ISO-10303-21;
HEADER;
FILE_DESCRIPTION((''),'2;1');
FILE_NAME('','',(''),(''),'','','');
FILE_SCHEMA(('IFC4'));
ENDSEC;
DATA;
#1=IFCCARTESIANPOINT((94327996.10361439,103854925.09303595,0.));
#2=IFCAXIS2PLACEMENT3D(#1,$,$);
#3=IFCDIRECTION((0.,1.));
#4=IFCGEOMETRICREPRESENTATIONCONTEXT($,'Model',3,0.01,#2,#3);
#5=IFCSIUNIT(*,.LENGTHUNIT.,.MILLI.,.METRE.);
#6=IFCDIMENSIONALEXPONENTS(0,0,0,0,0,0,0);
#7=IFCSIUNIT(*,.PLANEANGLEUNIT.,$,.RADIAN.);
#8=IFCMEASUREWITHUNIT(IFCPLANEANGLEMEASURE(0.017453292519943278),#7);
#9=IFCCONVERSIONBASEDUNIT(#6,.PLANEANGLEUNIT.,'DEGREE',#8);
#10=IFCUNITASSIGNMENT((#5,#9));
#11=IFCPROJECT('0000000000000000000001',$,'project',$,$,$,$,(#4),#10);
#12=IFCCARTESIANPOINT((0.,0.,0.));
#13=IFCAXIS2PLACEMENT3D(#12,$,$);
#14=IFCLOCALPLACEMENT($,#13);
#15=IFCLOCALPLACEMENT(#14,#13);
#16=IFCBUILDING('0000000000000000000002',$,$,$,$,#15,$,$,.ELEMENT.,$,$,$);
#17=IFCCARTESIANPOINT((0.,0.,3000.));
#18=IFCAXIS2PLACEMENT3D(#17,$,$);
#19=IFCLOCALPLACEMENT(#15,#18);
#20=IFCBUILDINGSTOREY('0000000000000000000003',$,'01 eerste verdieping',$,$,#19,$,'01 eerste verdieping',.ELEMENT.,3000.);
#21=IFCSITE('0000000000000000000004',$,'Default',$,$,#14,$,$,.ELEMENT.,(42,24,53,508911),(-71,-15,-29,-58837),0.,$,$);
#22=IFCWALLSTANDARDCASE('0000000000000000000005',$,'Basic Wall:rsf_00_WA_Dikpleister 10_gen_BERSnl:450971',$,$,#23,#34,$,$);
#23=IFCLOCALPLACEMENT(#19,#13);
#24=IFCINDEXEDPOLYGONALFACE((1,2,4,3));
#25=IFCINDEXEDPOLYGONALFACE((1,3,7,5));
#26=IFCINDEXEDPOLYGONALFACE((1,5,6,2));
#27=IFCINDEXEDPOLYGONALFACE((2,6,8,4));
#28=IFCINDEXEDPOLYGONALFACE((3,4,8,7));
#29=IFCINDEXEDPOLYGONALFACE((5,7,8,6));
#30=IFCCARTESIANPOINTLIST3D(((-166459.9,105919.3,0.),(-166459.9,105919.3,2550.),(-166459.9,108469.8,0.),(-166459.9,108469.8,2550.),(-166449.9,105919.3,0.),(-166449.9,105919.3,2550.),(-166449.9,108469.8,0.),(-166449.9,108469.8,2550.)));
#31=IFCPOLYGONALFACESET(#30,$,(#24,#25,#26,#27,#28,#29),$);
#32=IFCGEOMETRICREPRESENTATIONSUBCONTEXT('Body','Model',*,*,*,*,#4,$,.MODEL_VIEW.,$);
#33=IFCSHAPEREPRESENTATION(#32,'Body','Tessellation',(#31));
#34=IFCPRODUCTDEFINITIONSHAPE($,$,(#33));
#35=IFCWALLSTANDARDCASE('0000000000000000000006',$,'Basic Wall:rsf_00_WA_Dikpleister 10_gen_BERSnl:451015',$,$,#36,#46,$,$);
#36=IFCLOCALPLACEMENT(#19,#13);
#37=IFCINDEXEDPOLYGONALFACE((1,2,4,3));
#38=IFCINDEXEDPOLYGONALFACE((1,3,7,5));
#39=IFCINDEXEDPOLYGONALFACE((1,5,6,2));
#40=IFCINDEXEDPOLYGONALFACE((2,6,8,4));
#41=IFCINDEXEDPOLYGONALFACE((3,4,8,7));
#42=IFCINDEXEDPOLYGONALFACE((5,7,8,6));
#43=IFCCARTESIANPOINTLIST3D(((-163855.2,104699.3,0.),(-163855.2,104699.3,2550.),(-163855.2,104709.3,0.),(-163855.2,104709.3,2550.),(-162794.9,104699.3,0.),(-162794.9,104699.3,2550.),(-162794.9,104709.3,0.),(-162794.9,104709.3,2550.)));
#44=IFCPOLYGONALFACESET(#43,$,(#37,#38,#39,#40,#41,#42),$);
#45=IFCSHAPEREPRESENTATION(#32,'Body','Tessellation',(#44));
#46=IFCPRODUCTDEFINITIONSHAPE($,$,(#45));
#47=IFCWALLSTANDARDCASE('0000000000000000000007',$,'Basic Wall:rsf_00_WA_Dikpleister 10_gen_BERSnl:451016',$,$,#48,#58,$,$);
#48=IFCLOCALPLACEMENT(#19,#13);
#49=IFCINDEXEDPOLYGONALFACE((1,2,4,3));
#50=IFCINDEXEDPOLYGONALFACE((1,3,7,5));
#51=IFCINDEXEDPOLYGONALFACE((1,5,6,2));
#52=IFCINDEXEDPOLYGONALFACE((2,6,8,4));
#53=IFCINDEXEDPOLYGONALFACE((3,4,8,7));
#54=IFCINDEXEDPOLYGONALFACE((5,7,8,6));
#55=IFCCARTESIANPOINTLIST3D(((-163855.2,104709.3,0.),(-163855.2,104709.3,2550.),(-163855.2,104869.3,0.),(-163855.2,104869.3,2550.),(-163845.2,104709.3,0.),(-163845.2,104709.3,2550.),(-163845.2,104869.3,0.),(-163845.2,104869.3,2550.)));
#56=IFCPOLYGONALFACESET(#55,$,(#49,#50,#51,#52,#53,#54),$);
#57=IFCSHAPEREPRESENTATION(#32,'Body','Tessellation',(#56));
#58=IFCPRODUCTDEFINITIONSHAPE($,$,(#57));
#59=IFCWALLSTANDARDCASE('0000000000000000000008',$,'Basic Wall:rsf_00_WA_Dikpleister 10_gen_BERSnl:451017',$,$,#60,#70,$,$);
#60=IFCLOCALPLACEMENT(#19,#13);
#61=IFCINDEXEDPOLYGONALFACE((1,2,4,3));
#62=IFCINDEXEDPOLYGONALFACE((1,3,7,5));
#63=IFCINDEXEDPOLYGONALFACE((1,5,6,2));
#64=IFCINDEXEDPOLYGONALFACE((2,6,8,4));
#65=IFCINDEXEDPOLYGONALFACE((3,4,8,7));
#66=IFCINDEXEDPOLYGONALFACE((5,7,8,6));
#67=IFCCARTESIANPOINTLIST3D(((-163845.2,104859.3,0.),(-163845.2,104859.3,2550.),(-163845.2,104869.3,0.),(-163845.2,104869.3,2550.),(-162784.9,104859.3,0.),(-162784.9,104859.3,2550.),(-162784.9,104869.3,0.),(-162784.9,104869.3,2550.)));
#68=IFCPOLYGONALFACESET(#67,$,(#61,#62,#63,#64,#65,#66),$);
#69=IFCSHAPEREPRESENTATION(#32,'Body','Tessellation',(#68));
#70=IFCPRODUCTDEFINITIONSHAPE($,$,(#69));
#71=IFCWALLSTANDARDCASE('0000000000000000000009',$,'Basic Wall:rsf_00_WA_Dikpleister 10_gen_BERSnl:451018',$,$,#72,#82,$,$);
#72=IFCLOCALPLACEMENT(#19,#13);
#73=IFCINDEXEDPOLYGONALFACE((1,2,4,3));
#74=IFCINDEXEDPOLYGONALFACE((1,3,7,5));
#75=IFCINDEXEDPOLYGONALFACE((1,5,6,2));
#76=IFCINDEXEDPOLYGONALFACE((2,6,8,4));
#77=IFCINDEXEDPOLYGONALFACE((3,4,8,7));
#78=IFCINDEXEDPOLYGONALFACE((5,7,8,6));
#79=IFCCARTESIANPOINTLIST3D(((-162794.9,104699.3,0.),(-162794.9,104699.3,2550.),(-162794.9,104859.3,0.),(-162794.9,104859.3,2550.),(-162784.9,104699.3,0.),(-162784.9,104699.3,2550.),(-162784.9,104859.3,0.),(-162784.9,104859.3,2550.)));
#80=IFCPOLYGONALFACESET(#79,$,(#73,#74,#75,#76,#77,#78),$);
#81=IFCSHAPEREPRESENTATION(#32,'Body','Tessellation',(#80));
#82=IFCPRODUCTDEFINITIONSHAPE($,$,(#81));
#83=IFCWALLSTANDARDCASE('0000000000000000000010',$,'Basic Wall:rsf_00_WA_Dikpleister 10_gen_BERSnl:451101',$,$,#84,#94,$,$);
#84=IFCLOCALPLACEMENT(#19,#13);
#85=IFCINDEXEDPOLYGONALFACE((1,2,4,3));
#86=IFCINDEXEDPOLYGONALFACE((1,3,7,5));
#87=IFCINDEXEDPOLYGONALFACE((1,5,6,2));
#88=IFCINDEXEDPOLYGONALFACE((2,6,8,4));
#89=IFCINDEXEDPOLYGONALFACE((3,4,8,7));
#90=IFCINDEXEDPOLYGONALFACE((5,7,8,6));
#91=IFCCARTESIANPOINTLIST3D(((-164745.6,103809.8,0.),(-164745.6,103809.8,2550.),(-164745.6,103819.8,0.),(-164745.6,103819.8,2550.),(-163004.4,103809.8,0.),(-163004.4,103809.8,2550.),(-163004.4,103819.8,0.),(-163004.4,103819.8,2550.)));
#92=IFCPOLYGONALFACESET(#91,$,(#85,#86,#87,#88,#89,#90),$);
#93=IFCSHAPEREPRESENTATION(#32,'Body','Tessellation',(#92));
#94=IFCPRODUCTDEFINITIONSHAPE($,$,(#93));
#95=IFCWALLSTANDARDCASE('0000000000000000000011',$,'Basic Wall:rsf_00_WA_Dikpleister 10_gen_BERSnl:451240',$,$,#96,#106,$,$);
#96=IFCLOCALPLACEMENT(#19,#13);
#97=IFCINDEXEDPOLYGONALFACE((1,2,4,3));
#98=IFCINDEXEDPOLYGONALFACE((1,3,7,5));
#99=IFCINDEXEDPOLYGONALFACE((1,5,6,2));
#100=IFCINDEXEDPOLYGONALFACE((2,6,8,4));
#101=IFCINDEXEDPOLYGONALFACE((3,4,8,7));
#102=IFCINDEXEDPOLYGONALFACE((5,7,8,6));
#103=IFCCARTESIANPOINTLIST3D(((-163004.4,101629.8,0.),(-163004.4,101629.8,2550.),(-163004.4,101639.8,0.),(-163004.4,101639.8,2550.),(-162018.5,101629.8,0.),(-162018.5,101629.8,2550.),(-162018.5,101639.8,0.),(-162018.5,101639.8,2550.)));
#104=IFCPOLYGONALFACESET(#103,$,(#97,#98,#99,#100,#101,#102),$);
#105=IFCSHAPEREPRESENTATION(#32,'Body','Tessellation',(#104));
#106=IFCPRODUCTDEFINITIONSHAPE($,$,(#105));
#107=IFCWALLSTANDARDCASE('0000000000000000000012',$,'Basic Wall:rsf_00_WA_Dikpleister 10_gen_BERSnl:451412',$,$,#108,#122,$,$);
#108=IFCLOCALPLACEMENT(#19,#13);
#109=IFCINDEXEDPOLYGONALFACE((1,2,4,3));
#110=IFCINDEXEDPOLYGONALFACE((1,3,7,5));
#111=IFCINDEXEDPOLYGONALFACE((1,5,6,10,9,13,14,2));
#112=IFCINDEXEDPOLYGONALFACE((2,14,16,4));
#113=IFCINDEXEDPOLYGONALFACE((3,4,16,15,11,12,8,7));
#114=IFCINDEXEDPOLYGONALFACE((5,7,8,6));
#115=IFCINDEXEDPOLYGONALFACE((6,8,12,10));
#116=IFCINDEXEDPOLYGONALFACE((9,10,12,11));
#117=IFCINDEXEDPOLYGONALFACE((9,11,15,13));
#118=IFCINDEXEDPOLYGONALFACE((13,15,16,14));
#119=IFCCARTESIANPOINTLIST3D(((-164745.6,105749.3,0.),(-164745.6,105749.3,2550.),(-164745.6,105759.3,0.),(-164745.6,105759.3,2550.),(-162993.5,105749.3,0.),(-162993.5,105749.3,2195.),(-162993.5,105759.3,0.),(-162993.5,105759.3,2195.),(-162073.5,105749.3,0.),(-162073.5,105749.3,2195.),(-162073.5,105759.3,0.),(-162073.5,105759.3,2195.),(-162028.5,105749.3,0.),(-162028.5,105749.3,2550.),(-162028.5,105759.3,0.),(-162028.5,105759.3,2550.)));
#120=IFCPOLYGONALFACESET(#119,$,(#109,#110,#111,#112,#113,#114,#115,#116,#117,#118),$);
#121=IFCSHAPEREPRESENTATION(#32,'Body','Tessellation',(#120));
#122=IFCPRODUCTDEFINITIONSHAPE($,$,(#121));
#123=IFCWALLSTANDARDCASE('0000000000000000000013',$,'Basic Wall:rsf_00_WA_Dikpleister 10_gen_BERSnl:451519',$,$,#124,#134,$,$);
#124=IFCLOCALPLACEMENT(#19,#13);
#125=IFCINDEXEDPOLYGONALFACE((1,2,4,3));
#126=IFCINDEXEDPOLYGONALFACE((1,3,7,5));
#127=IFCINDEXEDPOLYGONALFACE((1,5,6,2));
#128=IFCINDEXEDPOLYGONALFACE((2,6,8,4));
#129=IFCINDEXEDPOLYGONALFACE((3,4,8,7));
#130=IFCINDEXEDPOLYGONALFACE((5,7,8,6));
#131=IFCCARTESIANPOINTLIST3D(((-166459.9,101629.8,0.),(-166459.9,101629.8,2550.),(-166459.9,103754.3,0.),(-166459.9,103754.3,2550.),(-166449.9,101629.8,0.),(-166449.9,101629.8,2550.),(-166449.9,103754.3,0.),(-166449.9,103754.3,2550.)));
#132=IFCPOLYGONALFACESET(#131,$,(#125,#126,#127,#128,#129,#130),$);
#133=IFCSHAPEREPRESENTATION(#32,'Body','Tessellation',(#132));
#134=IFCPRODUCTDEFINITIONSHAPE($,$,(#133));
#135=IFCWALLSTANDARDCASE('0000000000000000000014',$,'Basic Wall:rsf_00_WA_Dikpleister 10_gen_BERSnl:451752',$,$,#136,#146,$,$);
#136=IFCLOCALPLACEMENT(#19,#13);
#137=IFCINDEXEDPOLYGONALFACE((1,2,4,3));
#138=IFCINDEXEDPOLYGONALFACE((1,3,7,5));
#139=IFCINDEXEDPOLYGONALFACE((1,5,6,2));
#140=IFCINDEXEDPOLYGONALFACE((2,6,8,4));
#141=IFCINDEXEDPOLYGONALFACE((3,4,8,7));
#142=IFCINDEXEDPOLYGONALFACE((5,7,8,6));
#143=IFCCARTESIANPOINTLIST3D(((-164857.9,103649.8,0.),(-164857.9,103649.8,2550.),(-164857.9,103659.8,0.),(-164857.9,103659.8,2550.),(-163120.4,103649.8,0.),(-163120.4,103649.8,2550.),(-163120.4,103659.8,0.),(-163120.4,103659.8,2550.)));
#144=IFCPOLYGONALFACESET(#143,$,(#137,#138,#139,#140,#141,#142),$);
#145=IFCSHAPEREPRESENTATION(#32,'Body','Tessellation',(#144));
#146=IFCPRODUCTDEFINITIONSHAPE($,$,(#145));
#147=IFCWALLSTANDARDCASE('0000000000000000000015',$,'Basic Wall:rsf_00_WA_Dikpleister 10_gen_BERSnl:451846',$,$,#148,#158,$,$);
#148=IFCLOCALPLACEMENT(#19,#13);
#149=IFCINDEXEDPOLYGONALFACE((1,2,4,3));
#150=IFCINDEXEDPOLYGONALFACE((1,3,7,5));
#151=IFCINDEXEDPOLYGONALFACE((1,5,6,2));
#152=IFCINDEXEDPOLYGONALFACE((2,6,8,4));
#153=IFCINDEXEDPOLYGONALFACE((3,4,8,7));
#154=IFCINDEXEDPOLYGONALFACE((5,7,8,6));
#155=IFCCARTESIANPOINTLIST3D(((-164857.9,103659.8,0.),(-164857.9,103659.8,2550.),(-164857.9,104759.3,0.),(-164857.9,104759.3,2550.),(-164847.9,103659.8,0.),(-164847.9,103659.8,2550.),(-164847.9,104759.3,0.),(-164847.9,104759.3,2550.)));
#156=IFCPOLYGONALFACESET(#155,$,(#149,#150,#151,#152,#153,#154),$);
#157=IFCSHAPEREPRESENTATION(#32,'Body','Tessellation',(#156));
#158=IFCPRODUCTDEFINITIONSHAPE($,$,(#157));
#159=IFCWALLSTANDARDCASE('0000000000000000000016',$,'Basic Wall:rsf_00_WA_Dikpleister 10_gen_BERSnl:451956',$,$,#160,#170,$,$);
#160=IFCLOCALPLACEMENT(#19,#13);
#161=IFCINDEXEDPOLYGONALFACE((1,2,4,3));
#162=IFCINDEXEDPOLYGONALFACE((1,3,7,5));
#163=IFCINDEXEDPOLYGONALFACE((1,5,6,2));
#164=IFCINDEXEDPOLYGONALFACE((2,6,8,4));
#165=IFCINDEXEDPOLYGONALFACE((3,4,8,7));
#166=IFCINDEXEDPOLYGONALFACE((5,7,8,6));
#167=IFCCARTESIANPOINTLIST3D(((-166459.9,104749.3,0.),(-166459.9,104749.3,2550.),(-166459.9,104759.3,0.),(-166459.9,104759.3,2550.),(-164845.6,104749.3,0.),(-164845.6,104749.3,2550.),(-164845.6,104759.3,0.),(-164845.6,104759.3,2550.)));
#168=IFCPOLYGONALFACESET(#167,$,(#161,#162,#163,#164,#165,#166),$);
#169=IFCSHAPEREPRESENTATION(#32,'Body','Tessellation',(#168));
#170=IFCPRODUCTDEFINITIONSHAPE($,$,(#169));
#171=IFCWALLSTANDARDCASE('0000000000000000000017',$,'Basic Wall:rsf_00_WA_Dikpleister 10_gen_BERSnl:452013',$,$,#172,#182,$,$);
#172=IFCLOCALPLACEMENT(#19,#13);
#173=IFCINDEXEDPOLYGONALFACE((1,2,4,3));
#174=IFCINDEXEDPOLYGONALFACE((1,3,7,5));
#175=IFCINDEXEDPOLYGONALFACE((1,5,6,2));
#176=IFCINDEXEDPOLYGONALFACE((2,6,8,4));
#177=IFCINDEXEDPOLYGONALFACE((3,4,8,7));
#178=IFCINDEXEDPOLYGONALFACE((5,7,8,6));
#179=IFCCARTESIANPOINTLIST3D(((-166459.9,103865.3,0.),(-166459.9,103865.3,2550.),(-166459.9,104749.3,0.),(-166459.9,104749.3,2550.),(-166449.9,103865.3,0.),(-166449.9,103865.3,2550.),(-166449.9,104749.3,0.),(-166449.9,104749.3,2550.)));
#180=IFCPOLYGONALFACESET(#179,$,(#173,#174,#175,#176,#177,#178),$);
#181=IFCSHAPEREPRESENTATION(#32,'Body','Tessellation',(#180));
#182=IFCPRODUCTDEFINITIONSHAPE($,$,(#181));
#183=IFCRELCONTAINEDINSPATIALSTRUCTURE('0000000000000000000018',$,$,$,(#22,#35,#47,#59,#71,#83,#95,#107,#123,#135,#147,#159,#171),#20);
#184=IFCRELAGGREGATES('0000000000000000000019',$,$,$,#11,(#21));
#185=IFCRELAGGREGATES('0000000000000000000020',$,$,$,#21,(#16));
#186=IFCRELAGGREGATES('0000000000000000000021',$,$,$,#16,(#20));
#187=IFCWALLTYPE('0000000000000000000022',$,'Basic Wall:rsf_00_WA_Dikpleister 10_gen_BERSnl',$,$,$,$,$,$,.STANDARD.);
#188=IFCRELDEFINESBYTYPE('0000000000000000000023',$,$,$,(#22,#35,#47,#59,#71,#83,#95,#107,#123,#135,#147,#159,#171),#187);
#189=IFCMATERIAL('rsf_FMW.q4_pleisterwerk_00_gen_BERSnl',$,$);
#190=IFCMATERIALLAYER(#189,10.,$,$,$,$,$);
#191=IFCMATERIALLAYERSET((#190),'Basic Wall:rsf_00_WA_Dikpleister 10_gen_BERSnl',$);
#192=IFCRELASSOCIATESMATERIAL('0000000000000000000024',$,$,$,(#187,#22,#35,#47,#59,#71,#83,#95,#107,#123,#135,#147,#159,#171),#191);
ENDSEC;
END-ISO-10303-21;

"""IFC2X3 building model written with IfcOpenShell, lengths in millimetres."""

from ifc_helpers import new_model, entity, si_unit, converted_unit, direction, frame, frame_2d, origin, place, context, subcontext, project, spatial, rectangle, extrude, material, layer, layer_set, layer_usage, type_object, element, save


model = new_model("IFC2X3")

# Units and contexts
model_context = context("Model", 3, precision=0.01, world=frame((94327996.10361439, 103854925.09303595, 0.0)), true_north=direction((0.0, 1.0)))
body_context = subcontext(model_context, "Body", "Model", "MODEL_VIEW")
ifc_project = project(units=[si_unit("LENGTHUNIT", "METRE", prefix="MILLI"), converted_unit("PLANEANGLEUNIT", "DEGREE", entity("IfcPlaneAngleMeasure", 0.017453292519943278), si_unit("PLANEANGLEUNIT", "RADIAN"), dimensions=[0, 0, 0, 0, 0, 0, 0])], contexts=[model_context])

# Site, building, storey
site_placement = place(None, origin())
site = spatial("IfcSite", under=ifc_project, at=site_placement, Name="Default", CompositionType="ELEMENT", RefLatitude=(42, 24, 53, 508911), RefLongitude=(-71, -15, -29, -58837), RefElevation=0.0)
building_placement = place(site_placement, origin())
building = spatial("IfcBuilding", under=site, at=building_placement, CompositionType="ELEMENT")
storey_placement = place(building_placement, frame((0.0, 0.0, 3000.0)))
storey = spatial("IfcBuildingStorey", under=building, at=storey_placement, Name="01 eerste verdieping", LongName="01 eerste verdieping", CompositionType="ELEMENT", Elevation=3000.0)

# Shared definitions
ifc_material_1 = material(Name="rsf_FMW.q4_pleisterwerk_00_gen_BERSnl")

# Shared definitions
ifc_layer_1 = layer(ifc_material_1, 10.0)
ifc_layer_set_1 = layer_set([ifc_layer_1], Name="Basic Wall:rsf_00_WA_Dikpleister 10_gen_BERSnl")
wall_type_1 = type_object("IfcWallType", Name="Basic Wall:rsf_00_WA_Dikpleister 10_gen_BERSnl", PredefinedType="STANDARD", material=ifc_layer_set_1)

# Walls
ifc_layer_usage_1 = layer_usage(ifc_layer_set_1, "AXIS2", "POSITIVE", -5.0)
wall_1_placement = place(storey_placement, frame((-166454.9, 108469.8, 0.0), z_axis=(0.0, 0.0, 1.0), x_axis=(0.0, -1.0, 0.0)))
element("IfcWallStandardCase", 1, at=wall_1_placement, inside=storey, type_object=wall_type_1, material=ifc_layer_usage_1, Name="Basic Wall:rsf_00_WA_Dikpleister 10_gen_BERSnl:450971", context=body_context, shape_type="SweptSolid", body=[
    extrude(rectangle(XDim=2550.5, YDim=10.0, at=frame_2d((1275.2, 0.0), x_axis=(-1.0, 0.0))), origin(), (0.0, 0.0, 1.0), 2550.0),
])
ifc_layer_usage_2 = layer_usage(ifc_layer_set_1, "AXIS2", "NEGATIVE", 5.0)
wall_2_placement = place(storey_placement, frame((-163855.2, 104704.3, 0.0)))
element("IfcWallStandardCase", 2, at=wall_2_placement, inside=storey, type_object=wall_type_1, material=ifc_layer_usage_2, Name="Basic Wall:rsf_00_WA_Dikpleister 10_gen_BERSnl:451015", context=body_context, shape_type="SweptSolid", body=[
    extrude(rectangle(XDim=1060.4, YDim=10.0, at=frame_2d((530.2, 0.0), x_axis=(-1.0, 0.0))), origin(), (0.0, 0.0, 1.0), 2550.0),
])
ifc_layer_usage_3 = layer_usage(ifc_layer_set_1, "AXIS2", "NEGATIVE", 5.0)
wall_3_placement = place(storey_placement, frame((-163850.2, 104869.3, 0.0), z_axis=(0.0, 0.0, 1.0), x_axis=(0.0, -1.0, 0.0)))
element("IfcWallStandardCase", 3, at=wall_3_placement, inside=storey, type_object=wall_type_1, material=ifc_layer_usage_3, Name="Basic Wall:rsf_00_WA_Dikpleister 10_gen_BERSnl:451016", context=body_context, shape_type="SweptSolid", body=[
    extrude(rectangle(XDim=160.0, YDim=10.0, at=frame_2d((80.0, 0.0), x_axis=(-1.0, 0.0))), origin(), (0.0, 0.0, 1.0), 2550.0),
])
ifc_layer_usage_4 = layer_usage(ifc_layer_set_1, "AXIS2", "NEGATIVE", 5.0)
wall_4_placement = place(storey_placement, frame((-162784.9, 104864.3, 0.0), z_axis=(0.0, 0.0, 1.0), x_axis=(-1.0, 0.0, 0.0)))
element("IfcWallStandardCase", 4, at=wall_4_placement, inside=storey, type_object=wall_type_1, material=ifc_layer_usage_4, Name="Basic Wall:rsf_00_WA_Dikpleister 10_gen_BERSnl:451017", context=body_context, shape_type="SweptSolid", body=[
    extrude(rectangle(XDim=1060.4, YDim=10.0, at=frame_2d((530.2, 0.0), x_axis=(-1.0, 0.0))), origin(), (0.0, 0.0, 1.0), 2550.0),
])
ifc_layer_usage_5 = layer_usage(ifc_layer_set_1, "AXIS2", "NEGATIVE", 5.0)
wall_5_placement = place(storey_placement, frame((-162789.9, 104699.3, 0.0), z_axis=(0.0, 0.0, 1.0), x_axis=(0.0, 1.0, 0.0)))
element("IfcWallStandardCase", 5, at=wall_5_placement, inside=storey, type_object=wall_type_1, material=ifc_layer_usage_5, Name="Basic Wall:rsf_00_WA_Dikpleister 10_gen_BERSnl:451018", context=body_context, shape_type="SweptSolid", body=[
    extrude(rectangle(XDim=160.0, YDim=10.0, at=frame_2d((80.0, 0.0), x_axis=(-1.0, 0.0))), origin(), (0.0, 0.0, 1.0), 2550.0),
])
ifc_layer_usage_6 = layer_usage(ifc_layer_set_1, "AXIS2", "NEGATIVE", 5.0)
wall_6_placement = place(storey_placement, frame((-164745.6, 103814.8, 0.0)))
element("IfcWallStandardCase", 6, at=wall_6_placement, inside=storey, type_object=wall_type_1, material=ifc_layer_usage_6, Name="Basic Wall:rsf_00_WA_Dikpleister 10_gen_BERSnl:451101", context=body_context, shape_type="SweptSolid", body=[
    extrude(rectangle(XDim=1741.2, YDim=10.0, at=frame_2d((870.6, 0.0), x_axis=(-1.0, 0.0))), origin(), (0.0, 0.0, 1.0), 2550.0),
])

# Wall
ifc_layer_usage_7 = layer_usage(ifc_layer_set_1, "AXIS2", "NEGATIVE", 5.0)
wall_7_placement = place(storey_placement, frame((-163004.4, 101634.8, 0.0)))
element("IfcWallStandardCase", 7, at=wall_7_placement, inside=storey, type_object=wall_type_1, material=ifc_layer_usage_7, Name="Basic Wall:rsf_00_WA_Dikpleister 10_gen_BERSnl:451240", context=body_context, shape_type="SweptSolid", body=[
    extrude(rectangle(XDim=985.9, YDim=10.0, at=frame_2d((493.0, 0.0), x_axis=(-1.0, 0.0))), origin(), (0.0, 0.0, 1.0), 2550.0),
])

# Wall, opening
ifc_layer_usage_8 = layer_usage(ifc_layer_set_1, "AXIS2", "NEGATIVE", 5.0)
wall_8_placement = place(storey_placement, frame((-162028.5, 105754.3, 0.0), z_axis=(0.0, 0.0, 1.0), x_axis=(-1.0, 0.0, 0.0)))
wall_8 = element("IfcWallStandardCase", 8, at=wall_8_placement, inside=storey, type_object=wall_type_1, material=ifc_layer_usage_8, Name="Basic Wall:rsf_00_WA_Dikpleister 10_gen_BERSnl:451412", context=body_context, shape_type="SweptSolid", body=[
    extrude(rectangle(XDim=2717.1, YDim=10.0, at=frame_2d((1358.5, 0.0), x_axis=(1.0, 0.0))), origin(), (0.0, 0.0, 1.0), 2550.0),
])
opening_1_placement = place(wall_8_placement, frame((965.0, 5.0, -200.0)))
element("IfcOpeningElement", 9, at=opening_1_placement, cuts=wall_8, ObjectType="Opening", context=body_context, shape_type="SweptSolid", body=[
    extrude(rectangle(XDim=2395.0, YDim=920.0, at=frame_2d((1197.5, 460.0), x_axis=(-1.0, 0.0))), frame((0.0, 0.0, 0.0), z_axis=(0.0, -1.0, 0.0), x_axis=(0.0, 0.0, 1.0)), (0.0, 0.0, 1.0), 10.0),
])

# Walls
ifc_layer_usage_9 = layer_usage(ifc_layer_set_1, "AXIS2", "NEGATIVE", 5.0)
wall_9_placement = place(storey_placement, frame((-166454.9, 103754.3, 0.0), z_axis=(0.0, 0.0, 1.0), x_axis=(0.0, -1.0, 0.0)))
element("IfcWallStandardCase", 10, at=wall_9_placement, inside=storey, type_object=wall_type_1, material=ifc_layer_usage_9, Name="Basic Wall:rsf_00_WA_Dikpleister 10_gen_BERSnl:451519", context=body_context, shape_type="SweptSolid", body=[
    extrude(rectangle(XDim=2124.5, YDim=10.0, at=frame_2d((1062.3, 0.0), x_axis=(-1.0, 0.0))), origin(), (0.0, 0.0, 1.0), 2550.0),
])
ifc_layer_usage_10 = layer_usage(ifc_layer_set_1, "AXIS2", "NEGATIVE", 5.0)
wall_10_placement = place(storey_placement, frame((-163120.4, 103654.8, 0.0), z_axis=(0.0, 0.0, 1.0), x_axis=(-1.0, 0.0, 0.0)))
element("IfcWallStandardCase", 11, at=wall_10_placement, inside=storey, type_object=wall_type_1, material=ifc_layer_usage_10, Name="Basic Wall:rsf_00_WA_Dikpleister 10_gen_BERSnl:451752", context=body_context, shape_type="SweptSolid", body=[
    extrude(rectangle(XDim=1737.4, YDim=10.0, at=frame_2d((868.7, 0.0), x_axis=(-1.0, 0.0))), origin(), (0.0, 0.0, 1.0), 2550.0),
])
ifc_layer_usage_11 = layer_usage(ifc_layer_set_1, "AXIS2", "NEGATIVE", 5.0)
wall_11_placement = place(storey_placement, frame((-164852.9, 103659.8, 0.0), z_axis=(0.0, 0.0, 1.0), x_axis=(0.0, 1.0, 0.0)))
element("IfcWallStandardCase", 12, at=wall_11_placement, inside=storey, type_object=wall_type_1, material=ifc_layer_usage_11, Name="Basic Wall:rsf_00_WA_Dikpleister 10_gen_BERSnl:451846", context=body_context, shape_type="SweptSolid", body=[
    extrude(rectangle(XDim=1099.5, YDim=10.0, at=frame_2d((549.8, 0.0), x_axis=(-1.0, 0.0))), origin(), (0.0, 0.0, 1.0), 2550.0),
])
ifc_layer_usage_12 = layer_usage(ifc_layer_set_1, "AXIS2", "NEGATIVE", 5.0)
wall_12_placement = place(storey_placement, frame((-164845.6, 104754.3, 0.0), z_axis=(0.0, 0.0, 1.0), x_axis=(-1.0, 0.0, 0.0)))
element("IfcWallStandardCase", 13, at=wall_12_placement, inside=storey, type_object=wall_type_1, material=ifc_layer_usage_12, Name="Basic Wall:rsf_00_WA_Dikpleister 10_gen_BERSnl:451956", context=body_context, shape_type="SweptSolid", body=[
    extrude(rectangle(XDim=1614.3, YDim=10.0, at=frame_2d((807.1, 0.0), x_axis=(-1.0, 0.0))), origin(), (0.0, 0.0, 1.0), 2550.0),
])
ifc_layer_usage_13 = layer_usage(ifc_layer_set_1, "AXIS2", "NEGATIVE", 5.0)
wall_13_placement = place(storey_placement, frame((-166454.9, 104749.3, 0.0), z_axis=(0.0, 0.0, 1.0), x_axis=(0.0, -1.0, 0.0)))
element("IfcWallStandardCase", 14, at=wall_13_placement, inside=storey, type_object=wall_type_1, material=ifc_layer_usage_13, Name="Basic Wall:rsf_00_WA_Dikpleister 10_gen_BERSnl:452013", context=body_context, shape_type="SweptSolid", body=[
    extrude(rectangle(XDim=884.0, YDim=10.0, at=frame_2d((442.0, 0.0), x_axis=(-1.0, 0.0))), origin(), (0.0, 0.0, 1.0), 2550.0),
])

save(model, "model.ifc")
